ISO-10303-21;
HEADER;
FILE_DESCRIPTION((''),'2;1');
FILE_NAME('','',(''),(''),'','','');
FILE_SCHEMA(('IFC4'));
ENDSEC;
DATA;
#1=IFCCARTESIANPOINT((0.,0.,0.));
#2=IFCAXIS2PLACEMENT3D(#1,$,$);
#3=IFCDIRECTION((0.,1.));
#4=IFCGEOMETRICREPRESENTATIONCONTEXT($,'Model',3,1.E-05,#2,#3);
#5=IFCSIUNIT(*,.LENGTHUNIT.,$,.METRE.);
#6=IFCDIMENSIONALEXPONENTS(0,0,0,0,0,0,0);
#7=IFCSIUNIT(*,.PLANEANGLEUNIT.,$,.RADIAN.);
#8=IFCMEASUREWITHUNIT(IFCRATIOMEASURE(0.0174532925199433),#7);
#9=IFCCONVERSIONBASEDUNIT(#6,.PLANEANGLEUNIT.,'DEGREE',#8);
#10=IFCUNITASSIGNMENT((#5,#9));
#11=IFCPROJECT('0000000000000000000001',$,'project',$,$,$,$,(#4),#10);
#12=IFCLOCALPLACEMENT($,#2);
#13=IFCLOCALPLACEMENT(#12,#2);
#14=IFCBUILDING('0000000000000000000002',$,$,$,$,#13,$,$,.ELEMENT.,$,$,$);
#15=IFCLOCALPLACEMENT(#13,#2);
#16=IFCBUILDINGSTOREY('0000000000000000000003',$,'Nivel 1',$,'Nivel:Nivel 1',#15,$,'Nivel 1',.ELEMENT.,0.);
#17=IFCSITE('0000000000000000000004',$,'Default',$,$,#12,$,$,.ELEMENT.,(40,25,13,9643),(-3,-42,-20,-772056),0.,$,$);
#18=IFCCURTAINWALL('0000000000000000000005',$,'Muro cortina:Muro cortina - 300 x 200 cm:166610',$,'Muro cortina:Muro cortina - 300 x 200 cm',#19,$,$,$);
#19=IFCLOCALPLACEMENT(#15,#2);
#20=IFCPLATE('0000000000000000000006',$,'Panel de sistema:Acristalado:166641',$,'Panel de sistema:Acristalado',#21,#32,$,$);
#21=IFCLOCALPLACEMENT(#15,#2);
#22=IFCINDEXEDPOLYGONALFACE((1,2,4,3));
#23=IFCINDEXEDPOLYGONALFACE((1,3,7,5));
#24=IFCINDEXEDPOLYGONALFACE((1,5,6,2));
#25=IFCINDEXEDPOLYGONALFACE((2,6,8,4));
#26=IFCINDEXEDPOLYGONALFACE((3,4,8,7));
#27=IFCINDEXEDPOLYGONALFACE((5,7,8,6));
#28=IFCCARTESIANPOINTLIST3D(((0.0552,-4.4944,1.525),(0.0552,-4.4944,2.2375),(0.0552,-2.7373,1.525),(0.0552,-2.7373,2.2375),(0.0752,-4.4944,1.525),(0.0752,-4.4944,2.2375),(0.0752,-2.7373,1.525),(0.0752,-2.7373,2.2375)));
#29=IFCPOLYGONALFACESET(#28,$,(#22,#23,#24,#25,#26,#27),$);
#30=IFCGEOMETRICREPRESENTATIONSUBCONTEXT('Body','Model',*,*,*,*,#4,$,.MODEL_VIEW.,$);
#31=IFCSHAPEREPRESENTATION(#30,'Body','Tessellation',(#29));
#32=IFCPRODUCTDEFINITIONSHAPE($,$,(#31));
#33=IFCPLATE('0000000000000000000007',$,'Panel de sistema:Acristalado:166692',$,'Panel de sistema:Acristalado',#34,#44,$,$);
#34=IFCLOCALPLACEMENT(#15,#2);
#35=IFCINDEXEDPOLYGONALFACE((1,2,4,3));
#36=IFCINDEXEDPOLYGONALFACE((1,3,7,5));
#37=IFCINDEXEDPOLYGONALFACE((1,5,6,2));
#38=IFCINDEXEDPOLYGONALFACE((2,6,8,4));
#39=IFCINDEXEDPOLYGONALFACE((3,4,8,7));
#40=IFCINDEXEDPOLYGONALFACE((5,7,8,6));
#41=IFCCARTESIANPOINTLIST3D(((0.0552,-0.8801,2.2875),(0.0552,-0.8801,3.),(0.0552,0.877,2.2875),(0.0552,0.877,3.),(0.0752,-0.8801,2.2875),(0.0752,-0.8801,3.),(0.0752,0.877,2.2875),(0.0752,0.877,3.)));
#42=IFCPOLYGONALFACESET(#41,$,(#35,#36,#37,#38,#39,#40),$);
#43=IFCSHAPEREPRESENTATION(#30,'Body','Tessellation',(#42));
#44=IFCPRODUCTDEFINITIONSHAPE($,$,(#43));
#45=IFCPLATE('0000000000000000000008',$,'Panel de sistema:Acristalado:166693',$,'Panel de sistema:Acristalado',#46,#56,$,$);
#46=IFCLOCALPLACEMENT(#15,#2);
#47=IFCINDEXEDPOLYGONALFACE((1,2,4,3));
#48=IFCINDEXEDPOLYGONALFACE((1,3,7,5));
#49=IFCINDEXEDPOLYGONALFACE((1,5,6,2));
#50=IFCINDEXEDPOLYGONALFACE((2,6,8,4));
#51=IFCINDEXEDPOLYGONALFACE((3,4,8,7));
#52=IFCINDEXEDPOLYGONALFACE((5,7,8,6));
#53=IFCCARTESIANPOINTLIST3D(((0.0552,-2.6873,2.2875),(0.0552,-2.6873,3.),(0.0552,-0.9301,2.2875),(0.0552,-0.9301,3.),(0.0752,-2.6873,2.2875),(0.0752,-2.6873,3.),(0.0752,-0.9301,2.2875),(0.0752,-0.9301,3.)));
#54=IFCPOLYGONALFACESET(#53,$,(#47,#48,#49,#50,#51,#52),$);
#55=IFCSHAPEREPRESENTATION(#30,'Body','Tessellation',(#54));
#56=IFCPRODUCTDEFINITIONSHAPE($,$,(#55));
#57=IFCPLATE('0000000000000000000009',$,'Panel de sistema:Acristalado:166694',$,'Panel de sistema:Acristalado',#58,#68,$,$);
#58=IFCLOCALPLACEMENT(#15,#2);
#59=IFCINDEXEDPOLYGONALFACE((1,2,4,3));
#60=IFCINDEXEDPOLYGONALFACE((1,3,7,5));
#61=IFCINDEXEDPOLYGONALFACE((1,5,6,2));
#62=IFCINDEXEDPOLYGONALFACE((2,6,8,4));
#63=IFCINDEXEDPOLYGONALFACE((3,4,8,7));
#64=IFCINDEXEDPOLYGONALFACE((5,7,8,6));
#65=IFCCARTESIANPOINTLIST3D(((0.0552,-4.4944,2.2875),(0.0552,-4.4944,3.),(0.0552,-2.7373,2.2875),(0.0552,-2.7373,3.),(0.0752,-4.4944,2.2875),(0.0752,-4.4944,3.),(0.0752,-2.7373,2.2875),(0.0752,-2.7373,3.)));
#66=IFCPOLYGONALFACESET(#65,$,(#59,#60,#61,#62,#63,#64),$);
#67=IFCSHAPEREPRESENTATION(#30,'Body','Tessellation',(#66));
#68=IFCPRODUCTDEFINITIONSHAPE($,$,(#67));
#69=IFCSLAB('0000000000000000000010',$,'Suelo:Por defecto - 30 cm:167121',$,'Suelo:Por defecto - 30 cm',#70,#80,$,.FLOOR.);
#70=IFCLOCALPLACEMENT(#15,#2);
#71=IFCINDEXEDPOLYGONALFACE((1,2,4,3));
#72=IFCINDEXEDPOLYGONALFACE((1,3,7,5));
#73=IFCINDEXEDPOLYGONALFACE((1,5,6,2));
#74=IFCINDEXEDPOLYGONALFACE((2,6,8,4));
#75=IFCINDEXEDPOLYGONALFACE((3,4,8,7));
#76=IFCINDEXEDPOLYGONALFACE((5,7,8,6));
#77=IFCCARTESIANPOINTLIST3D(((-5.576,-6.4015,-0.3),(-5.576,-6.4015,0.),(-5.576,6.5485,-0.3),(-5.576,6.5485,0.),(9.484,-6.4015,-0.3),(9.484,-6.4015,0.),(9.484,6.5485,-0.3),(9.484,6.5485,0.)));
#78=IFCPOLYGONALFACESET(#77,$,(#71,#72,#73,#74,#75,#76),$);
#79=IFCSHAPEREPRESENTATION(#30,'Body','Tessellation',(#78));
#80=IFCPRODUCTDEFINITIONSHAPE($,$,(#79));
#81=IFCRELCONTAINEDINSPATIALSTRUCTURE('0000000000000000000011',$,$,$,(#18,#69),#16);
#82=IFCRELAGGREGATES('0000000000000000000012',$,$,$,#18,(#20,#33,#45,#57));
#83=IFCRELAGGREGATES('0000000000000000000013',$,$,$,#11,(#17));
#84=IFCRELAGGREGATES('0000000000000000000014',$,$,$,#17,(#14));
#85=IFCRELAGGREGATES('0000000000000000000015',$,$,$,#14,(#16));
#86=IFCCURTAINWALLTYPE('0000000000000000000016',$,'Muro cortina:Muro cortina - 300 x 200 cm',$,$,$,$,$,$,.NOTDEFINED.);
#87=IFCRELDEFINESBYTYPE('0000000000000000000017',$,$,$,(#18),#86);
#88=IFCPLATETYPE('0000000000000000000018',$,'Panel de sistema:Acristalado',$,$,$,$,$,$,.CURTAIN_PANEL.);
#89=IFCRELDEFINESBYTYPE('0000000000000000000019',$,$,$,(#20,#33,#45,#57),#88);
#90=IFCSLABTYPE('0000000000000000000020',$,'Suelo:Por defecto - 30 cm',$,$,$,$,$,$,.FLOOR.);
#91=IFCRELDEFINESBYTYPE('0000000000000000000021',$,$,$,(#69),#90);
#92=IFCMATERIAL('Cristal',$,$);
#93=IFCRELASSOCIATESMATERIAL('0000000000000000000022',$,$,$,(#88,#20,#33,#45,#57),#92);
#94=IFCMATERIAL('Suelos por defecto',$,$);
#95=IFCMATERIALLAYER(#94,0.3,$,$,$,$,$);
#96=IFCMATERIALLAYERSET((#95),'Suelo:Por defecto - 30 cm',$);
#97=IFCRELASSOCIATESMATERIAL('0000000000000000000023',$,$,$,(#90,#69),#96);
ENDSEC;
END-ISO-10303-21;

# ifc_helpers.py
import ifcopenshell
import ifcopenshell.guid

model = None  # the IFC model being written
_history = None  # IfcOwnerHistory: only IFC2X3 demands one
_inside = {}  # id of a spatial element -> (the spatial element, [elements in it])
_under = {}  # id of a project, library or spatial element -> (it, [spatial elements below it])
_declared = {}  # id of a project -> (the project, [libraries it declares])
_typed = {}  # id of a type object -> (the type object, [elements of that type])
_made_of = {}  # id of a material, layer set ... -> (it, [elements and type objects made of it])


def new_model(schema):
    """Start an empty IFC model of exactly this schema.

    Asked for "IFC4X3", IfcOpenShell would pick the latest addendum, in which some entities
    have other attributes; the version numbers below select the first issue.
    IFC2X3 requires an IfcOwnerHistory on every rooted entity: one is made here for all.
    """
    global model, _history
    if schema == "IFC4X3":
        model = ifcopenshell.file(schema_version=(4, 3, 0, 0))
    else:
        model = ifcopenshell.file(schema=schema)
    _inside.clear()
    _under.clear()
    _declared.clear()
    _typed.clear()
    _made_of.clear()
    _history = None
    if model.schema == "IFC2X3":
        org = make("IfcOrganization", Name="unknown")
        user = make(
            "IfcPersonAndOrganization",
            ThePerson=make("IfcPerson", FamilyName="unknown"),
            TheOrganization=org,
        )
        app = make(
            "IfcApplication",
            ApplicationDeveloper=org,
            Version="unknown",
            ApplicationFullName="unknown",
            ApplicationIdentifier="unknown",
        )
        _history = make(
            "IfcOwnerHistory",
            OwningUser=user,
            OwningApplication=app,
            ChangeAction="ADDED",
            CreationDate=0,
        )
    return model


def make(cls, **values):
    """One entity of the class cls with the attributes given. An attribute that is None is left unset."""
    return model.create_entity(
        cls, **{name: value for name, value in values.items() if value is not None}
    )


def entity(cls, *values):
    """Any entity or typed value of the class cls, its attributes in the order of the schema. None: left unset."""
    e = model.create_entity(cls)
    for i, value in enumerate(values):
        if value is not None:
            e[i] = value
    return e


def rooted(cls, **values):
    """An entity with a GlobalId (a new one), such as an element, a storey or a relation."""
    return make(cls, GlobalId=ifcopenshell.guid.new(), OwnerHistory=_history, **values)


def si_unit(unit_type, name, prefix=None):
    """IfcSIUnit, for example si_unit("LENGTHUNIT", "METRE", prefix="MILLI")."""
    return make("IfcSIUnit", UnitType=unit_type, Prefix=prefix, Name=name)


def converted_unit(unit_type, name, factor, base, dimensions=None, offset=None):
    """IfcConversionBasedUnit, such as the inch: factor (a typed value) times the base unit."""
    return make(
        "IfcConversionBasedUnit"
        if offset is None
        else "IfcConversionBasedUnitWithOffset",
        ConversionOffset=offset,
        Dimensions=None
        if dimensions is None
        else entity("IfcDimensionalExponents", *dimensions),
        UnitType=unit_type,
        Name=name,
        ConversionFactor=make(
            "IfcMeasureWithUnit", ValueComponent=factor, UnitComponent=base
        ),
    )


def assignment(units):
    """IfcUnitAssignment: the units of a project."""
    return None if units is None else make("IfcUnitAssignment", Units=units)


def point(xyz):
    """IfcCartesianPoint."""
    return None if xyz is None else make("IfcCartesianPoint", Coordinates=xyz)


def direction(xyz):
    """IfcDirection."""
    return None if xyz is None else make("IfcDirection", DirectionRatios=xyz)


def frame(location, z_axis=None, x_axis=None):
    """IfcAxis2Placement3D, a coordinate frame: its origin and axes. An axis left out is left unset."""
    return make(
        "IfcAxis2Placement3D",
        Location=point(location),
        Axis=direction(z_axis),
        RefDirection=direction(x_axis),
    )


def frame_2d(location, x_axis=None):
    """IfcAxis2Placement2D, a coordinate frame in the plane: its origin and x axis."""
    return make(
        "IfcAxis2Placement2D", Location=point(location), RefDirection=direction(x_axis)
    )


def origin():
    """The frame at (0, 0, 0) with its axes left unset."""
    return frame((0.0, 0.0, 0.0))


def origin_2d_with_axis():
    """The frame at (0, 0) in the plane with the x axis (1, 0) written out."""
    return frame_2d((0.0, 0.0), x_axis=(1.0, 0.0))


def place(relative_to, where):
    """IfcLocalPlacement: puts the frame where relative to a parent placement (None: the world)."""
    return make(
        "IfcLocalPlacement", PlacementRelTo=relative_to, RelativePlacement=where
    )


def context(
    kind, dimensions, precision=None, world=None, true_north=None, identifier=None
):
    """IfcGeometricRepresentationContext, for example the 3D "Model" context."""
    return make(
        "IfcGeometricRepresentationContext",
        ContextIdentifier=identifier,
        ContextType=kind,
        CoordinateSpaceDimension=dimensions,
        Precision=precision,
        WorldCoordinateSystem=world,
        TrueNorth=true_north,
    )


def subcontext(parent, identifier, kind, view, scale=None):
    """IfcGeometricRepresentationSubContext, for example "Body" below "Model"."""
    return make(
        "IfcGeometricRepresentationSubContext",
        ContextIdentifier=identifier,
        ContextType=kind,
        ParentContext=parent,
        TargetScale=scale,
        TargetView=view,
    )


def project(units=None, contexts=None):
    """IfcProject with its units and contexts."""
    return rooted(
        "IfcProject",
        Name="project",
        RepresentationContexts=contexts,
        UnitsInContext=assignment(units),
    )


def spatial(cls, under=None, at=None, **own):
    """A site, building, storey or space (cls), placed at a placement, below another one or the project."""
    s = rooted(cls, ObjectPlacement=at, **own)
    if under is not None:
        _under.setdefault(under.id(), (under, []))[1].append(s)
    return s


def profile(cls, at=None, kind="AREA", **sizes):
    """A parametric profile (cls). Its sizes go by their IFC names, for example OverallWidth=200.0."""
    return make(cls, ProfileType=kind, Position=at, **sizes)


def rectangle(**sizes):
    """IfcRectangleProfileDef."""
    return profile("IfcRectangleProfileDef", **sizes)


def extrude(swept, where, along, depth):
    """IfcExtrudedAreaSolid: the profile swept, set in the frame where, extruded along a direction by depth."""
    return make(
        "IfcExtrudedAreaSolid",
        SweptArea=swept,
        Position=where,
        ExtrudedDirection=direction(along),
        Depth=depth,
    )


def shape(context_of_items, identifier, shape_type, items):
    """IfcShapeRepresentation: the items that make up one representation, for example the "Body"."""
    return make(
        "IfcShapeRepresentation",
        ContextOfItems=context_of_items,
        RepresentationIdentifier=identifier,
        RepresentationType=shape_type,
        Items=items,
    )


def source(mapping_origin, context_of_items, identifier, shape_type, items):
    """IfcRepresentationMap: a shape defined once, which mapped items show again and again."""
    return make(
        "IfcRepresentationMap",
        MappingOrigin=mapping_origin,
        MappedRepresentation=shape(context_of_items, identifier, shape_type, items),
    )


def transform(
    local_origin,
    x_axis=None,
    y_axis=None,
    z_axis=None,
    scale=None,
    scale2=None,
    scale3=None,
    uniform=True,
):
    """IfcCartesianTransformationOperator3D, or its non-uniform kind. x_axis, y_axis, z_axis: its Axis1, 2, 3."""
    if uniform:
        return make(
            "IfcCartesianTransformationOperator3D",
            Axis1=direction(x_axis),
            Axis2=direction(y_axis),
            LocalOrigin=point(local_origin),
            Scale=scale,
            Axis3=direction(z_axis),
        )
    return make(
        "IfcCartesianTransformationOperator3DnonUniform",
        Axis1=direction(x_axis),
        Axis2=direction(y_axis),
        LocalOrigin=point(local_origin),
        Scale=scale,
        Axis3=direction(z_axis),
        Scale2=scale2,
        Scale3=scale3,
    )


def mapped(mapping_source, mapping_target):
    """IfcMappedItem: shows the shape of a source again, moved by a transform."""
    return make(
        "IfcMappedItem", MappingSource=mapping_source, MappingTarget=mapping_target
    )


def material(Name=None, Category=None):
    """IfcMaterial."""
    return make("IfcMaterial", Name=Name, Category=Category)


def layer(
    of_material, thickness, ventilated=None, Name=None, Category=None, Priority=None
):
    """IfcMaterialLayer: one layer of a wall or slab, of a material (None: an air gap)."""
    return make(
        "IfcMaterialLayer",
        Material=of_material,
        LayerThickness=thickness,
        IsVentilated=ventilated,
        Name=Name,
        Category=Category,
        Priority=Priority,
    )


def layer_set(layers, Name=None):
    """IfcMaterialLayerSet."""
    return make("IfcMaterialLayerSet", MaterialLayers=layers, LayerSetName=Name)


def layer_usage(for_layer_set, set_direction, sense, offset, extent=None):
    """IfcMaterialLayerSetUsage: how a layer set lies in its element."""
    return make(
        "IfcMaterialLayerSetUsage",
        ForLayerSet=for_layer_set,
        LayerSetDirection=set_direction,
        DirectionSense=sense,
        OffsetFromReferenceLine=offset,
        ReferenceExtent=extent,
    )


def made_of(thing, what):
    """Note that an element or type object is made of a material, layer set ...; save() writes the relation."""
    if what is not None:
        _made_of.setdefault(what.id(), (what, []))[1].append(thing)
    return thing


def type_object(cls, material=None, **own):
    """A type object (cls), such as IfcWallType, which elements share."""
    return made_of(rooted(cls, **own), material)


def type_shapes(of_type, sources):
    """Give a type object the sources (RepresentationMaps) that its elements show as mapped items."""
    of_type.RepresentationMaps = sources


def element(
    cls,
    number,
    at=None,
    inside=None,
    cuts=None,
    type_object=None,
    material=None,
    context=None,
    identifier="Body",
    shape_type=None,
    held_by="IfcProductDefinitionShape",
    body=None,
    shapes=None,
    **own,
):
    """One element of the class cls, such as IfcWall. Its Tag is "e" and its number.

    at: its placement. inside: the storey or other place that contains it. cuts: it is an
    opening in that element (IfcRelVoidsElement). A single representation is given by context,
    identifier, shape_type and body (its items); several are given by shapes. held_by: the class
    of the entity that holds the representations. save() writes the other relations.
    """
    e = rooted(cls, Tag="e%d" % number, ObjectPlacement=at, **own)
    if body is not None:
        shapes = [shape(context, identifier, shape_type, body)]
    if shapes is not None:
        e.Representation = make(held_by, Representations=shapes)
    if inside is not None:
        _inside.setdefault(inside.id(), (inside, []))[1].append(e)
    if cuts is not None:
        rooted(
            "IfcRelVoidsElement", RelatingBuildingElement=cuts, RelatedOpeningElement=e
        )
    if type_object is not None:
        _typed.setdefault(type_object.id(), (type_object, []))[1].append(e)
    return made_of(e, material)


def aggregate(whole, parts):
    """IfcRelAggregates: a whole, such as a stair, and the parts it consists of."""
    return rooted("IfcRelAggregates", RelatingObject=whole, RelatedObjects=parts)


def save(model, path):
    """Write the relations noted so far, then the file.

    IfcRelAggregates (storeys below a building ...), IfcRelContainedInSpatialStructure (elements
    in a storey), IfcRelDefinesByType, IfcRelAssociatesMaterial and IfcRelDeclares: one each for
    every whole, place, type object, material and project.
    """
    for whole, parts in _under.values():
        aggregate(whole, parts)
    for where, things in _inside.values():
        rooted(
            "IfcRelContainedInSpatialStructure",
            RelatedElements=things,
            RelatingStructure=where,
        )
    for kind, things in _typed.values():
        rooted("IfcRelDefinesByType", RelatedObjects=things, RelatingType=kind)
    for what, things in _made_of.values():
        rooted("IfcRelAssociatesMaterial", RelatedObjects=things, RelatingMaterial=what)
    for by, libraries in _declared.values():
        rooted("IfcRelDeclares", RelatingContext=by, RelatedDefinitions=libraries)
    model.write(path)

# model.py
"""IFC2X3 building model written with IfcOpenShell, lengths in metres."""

from ifc_helpers import new_model, entity, si_unit, converted_unit, direction, frame, origin, origin_2d_with_axis, place, context, subcontext, project, spatial, rectangle, extrude, source, transform, mapped, material, layer, layer_set, layer_usage, type_object, type_shapes, element, aggregate, save


model = new_model("IFC2X3")

# Units and contexts
model_context = context("Model", 3, precision=1e-05, world=origin(), true_north=direction((0.0, 1.0)))
body_context = subcontext(model_context, "Body", "Model", "MODEL_VIEW")
ifc_project = project(units=[si_unit("LENGTHUNIT", "METRE"), converted_unit("PLANEANGLEUNIT", "DEGREE", entity("IfcRatioMeasure", 0.0174532925199433), si_unit("PLANEANGLEUNIT", "RADIAN"), dimensions=[0, 0, 0, 0, 0, 0, 0])], contexts=[model_context])

# Site, building, storey
site_placement = place(None, origin())
site = spatial("IfcSite", under=ifc_project, at=site_placement, Name="Default", CompositionType="ELEMENT", RefLatitude=(40, 25, 13, 9643), RefLongitude=(-3, -42, -20, -772056), RefElevation=0.0)
building_placement = place(site_placement, origin())
building = spatial("IfcBuilding", under=site, at=building_placement, CompositionType="ELEMENT")
storey_placement = place(building_placement, origin())
storey = spatial("IfcBuildingStorey", under=building, at=storey_placement, Name="Nivel 1", ObjectType="Nivel:Nivel 1", LongName="Nivel 1", CompositionType="ELEMENT", Elevation=0.0)

# Curtain wall, plates
curtain_wall_type = type_object("IfcCurtainWallType", Name="Muro cortina:Muro cortina - 300 x 200 cm", PredefinedType="NOTDEFINED")
curtain_wall_placement = place(storey_placement, origin())
curtain_wall = element("IfcCurtainWall", 1, at=curtain_wall_placement, inside=storey, type_object=curtain_wall_type, Name="Muro cortina:Muro cortina - 300 x 200 cm:166610", ObjectType="Muro cortina:Muro cortina - 300 x 200 cm")
ifc_material_1 = material(Name="Cristal")
plate_type = type_object("IfcPlateType", Name="Panel de sistema:Acristalado", PredefinedType="CURTAIN_PANEL", material=ifc_material_1)
shared_shape_1 = source(origin(), body_context, "Body", "SweptSolid", [
    extrude(rectangle(XDim=0.02, YDim=1.7571, at=origin_2d_with_axis()), frame((0.0, 0.0, 0.0), z_axis=(0.0, 0.0, 1.0), x_axis=(0.0, 1.0, 0.0)), (0.0, 0.0, 1.0), 0.7125),
])
type_shapes(plate_type, [shared_shape_1])
plate_1_placement = place(curtain_wall_placement, frame((0.0652, -3.6158, 1.525), z_axis=(0.0, 0.0, 1.0), x_axis=(0.0, -1.0, 0.0)))
plate_1 = element("IfcPlate", 2, at=plate_1_placement, type_object=plate_type, material=ifc_material_1, Name="Panel de sistema:Acristalado:166641", ObjectType="Panel de sistema:Acristalado", context=body_context, shape_type="MappedRepresentation", body=[
    mapped(shared_shape_1, transform((0.0, 0.0, 0.0), scale=1.0)),
])
plate_2_placement = place(curtain_wall_placement, frame((0.0652, -0.0015, 2.2875), z_axis=(0.0, 0.0, 1.0), x_axis=(0.0, -1.0, 0.0)))
plate_2 = element("IfcPlate", 3, at=plate_2_placement, type_object=plate_type, material=ifc_material_1, Name="Panel de sistema:Acristalado:166692", ObjectType="Panel de sistema:Acristalado", context=body_context, shape_type="MappedRepresentation", body=[
    mapped(shared_shape_1, transform((0.0, 0.0, 0.0), scale=1.0)),
])
plate_3_placement = place(curtain_wall_placement, frame((0.0652, -1.8087, 2.2875), z_axis=(0.0, 0.0, 1.0), x_axis=(0.0, -1.0, 0.0)))
plate_3 = element("IfcPlate", 4, at=plate_3_placement, type_object=plate_type, material=ifc_material_1, Name="Panel de sistema:Acristalado:166693", ObjectType="Panel de sistema:Acristalado", context=body_context, shape_type="MappedRepresentation", body=[
    mapped(shared_shape_1, transform((0.0, 0.0, 0.0), scale=1.0)),
])
plate_4_placement = place(curtain_wall_placement, frame((0.0652, -3.6158, 2.2875), z_axis=(0.0, 0.0, 1.0), x_axis=(0.0, -1.0, 0.0)))
plate_4 = element("IfcPlate", 5, at=plate_4_placement, type_object=plate_type, material=ifc_material_1, Name="Panel de sistema:Acristalado:166694", ObjectType="Panel de sistema:Acristalado", context=body_context, shape_type="MappedRepresentation", body=[
    mapped(shared_shape_1, transform((0.0, 0.0, 0.0), scale=1.0)),
])
aggregate(curtain_wall, [plate_1, plate_2, plate_3, plate_4])

# Slab
ifc_material_2 = material(Name="Suelos por defecto")
ifc_layer = layer(ifc_material_2, 0.3)
ifc_layer_set = layer_set([ifc_layer], Name="Suelo:Por defecto - 30 cm")
ifc_layer_usage = layer_usage(ifc_layer_set, "AXIS3", "POSITIVE", 0.0)
slab_type = type_object("IfcSlabType", Name="Suelo:Por defecto - 30 cm", PredefinedType="FLOOR", material=ifc_layer_set)
slab_placement = place(storey_placement, origin())
element("IfcSlab", 6, at=slab_placement, inside=storey, type_object=slab_type, material=ifc_layer_usage, Name="Suelo:Por defecto - 30 cm:167121", ObjectType="Suelo:Por defecto - 30 cm", PredefinedType="FLOOR", context=body_context, shape_type="SweptSolid", body=[
    extrude(rectangle(XDim=12.95, YDim=15.06, at=origin_2d_with_axis()), frame((1.954, 0.0735, 0.0), z_axis=(0.0, 0.0, -1.0), x_axis=(0.0, 1.0, 0.0)), (0.0, 0.0, 1.0), 0.3),
])

save(model, "model.ifc")
